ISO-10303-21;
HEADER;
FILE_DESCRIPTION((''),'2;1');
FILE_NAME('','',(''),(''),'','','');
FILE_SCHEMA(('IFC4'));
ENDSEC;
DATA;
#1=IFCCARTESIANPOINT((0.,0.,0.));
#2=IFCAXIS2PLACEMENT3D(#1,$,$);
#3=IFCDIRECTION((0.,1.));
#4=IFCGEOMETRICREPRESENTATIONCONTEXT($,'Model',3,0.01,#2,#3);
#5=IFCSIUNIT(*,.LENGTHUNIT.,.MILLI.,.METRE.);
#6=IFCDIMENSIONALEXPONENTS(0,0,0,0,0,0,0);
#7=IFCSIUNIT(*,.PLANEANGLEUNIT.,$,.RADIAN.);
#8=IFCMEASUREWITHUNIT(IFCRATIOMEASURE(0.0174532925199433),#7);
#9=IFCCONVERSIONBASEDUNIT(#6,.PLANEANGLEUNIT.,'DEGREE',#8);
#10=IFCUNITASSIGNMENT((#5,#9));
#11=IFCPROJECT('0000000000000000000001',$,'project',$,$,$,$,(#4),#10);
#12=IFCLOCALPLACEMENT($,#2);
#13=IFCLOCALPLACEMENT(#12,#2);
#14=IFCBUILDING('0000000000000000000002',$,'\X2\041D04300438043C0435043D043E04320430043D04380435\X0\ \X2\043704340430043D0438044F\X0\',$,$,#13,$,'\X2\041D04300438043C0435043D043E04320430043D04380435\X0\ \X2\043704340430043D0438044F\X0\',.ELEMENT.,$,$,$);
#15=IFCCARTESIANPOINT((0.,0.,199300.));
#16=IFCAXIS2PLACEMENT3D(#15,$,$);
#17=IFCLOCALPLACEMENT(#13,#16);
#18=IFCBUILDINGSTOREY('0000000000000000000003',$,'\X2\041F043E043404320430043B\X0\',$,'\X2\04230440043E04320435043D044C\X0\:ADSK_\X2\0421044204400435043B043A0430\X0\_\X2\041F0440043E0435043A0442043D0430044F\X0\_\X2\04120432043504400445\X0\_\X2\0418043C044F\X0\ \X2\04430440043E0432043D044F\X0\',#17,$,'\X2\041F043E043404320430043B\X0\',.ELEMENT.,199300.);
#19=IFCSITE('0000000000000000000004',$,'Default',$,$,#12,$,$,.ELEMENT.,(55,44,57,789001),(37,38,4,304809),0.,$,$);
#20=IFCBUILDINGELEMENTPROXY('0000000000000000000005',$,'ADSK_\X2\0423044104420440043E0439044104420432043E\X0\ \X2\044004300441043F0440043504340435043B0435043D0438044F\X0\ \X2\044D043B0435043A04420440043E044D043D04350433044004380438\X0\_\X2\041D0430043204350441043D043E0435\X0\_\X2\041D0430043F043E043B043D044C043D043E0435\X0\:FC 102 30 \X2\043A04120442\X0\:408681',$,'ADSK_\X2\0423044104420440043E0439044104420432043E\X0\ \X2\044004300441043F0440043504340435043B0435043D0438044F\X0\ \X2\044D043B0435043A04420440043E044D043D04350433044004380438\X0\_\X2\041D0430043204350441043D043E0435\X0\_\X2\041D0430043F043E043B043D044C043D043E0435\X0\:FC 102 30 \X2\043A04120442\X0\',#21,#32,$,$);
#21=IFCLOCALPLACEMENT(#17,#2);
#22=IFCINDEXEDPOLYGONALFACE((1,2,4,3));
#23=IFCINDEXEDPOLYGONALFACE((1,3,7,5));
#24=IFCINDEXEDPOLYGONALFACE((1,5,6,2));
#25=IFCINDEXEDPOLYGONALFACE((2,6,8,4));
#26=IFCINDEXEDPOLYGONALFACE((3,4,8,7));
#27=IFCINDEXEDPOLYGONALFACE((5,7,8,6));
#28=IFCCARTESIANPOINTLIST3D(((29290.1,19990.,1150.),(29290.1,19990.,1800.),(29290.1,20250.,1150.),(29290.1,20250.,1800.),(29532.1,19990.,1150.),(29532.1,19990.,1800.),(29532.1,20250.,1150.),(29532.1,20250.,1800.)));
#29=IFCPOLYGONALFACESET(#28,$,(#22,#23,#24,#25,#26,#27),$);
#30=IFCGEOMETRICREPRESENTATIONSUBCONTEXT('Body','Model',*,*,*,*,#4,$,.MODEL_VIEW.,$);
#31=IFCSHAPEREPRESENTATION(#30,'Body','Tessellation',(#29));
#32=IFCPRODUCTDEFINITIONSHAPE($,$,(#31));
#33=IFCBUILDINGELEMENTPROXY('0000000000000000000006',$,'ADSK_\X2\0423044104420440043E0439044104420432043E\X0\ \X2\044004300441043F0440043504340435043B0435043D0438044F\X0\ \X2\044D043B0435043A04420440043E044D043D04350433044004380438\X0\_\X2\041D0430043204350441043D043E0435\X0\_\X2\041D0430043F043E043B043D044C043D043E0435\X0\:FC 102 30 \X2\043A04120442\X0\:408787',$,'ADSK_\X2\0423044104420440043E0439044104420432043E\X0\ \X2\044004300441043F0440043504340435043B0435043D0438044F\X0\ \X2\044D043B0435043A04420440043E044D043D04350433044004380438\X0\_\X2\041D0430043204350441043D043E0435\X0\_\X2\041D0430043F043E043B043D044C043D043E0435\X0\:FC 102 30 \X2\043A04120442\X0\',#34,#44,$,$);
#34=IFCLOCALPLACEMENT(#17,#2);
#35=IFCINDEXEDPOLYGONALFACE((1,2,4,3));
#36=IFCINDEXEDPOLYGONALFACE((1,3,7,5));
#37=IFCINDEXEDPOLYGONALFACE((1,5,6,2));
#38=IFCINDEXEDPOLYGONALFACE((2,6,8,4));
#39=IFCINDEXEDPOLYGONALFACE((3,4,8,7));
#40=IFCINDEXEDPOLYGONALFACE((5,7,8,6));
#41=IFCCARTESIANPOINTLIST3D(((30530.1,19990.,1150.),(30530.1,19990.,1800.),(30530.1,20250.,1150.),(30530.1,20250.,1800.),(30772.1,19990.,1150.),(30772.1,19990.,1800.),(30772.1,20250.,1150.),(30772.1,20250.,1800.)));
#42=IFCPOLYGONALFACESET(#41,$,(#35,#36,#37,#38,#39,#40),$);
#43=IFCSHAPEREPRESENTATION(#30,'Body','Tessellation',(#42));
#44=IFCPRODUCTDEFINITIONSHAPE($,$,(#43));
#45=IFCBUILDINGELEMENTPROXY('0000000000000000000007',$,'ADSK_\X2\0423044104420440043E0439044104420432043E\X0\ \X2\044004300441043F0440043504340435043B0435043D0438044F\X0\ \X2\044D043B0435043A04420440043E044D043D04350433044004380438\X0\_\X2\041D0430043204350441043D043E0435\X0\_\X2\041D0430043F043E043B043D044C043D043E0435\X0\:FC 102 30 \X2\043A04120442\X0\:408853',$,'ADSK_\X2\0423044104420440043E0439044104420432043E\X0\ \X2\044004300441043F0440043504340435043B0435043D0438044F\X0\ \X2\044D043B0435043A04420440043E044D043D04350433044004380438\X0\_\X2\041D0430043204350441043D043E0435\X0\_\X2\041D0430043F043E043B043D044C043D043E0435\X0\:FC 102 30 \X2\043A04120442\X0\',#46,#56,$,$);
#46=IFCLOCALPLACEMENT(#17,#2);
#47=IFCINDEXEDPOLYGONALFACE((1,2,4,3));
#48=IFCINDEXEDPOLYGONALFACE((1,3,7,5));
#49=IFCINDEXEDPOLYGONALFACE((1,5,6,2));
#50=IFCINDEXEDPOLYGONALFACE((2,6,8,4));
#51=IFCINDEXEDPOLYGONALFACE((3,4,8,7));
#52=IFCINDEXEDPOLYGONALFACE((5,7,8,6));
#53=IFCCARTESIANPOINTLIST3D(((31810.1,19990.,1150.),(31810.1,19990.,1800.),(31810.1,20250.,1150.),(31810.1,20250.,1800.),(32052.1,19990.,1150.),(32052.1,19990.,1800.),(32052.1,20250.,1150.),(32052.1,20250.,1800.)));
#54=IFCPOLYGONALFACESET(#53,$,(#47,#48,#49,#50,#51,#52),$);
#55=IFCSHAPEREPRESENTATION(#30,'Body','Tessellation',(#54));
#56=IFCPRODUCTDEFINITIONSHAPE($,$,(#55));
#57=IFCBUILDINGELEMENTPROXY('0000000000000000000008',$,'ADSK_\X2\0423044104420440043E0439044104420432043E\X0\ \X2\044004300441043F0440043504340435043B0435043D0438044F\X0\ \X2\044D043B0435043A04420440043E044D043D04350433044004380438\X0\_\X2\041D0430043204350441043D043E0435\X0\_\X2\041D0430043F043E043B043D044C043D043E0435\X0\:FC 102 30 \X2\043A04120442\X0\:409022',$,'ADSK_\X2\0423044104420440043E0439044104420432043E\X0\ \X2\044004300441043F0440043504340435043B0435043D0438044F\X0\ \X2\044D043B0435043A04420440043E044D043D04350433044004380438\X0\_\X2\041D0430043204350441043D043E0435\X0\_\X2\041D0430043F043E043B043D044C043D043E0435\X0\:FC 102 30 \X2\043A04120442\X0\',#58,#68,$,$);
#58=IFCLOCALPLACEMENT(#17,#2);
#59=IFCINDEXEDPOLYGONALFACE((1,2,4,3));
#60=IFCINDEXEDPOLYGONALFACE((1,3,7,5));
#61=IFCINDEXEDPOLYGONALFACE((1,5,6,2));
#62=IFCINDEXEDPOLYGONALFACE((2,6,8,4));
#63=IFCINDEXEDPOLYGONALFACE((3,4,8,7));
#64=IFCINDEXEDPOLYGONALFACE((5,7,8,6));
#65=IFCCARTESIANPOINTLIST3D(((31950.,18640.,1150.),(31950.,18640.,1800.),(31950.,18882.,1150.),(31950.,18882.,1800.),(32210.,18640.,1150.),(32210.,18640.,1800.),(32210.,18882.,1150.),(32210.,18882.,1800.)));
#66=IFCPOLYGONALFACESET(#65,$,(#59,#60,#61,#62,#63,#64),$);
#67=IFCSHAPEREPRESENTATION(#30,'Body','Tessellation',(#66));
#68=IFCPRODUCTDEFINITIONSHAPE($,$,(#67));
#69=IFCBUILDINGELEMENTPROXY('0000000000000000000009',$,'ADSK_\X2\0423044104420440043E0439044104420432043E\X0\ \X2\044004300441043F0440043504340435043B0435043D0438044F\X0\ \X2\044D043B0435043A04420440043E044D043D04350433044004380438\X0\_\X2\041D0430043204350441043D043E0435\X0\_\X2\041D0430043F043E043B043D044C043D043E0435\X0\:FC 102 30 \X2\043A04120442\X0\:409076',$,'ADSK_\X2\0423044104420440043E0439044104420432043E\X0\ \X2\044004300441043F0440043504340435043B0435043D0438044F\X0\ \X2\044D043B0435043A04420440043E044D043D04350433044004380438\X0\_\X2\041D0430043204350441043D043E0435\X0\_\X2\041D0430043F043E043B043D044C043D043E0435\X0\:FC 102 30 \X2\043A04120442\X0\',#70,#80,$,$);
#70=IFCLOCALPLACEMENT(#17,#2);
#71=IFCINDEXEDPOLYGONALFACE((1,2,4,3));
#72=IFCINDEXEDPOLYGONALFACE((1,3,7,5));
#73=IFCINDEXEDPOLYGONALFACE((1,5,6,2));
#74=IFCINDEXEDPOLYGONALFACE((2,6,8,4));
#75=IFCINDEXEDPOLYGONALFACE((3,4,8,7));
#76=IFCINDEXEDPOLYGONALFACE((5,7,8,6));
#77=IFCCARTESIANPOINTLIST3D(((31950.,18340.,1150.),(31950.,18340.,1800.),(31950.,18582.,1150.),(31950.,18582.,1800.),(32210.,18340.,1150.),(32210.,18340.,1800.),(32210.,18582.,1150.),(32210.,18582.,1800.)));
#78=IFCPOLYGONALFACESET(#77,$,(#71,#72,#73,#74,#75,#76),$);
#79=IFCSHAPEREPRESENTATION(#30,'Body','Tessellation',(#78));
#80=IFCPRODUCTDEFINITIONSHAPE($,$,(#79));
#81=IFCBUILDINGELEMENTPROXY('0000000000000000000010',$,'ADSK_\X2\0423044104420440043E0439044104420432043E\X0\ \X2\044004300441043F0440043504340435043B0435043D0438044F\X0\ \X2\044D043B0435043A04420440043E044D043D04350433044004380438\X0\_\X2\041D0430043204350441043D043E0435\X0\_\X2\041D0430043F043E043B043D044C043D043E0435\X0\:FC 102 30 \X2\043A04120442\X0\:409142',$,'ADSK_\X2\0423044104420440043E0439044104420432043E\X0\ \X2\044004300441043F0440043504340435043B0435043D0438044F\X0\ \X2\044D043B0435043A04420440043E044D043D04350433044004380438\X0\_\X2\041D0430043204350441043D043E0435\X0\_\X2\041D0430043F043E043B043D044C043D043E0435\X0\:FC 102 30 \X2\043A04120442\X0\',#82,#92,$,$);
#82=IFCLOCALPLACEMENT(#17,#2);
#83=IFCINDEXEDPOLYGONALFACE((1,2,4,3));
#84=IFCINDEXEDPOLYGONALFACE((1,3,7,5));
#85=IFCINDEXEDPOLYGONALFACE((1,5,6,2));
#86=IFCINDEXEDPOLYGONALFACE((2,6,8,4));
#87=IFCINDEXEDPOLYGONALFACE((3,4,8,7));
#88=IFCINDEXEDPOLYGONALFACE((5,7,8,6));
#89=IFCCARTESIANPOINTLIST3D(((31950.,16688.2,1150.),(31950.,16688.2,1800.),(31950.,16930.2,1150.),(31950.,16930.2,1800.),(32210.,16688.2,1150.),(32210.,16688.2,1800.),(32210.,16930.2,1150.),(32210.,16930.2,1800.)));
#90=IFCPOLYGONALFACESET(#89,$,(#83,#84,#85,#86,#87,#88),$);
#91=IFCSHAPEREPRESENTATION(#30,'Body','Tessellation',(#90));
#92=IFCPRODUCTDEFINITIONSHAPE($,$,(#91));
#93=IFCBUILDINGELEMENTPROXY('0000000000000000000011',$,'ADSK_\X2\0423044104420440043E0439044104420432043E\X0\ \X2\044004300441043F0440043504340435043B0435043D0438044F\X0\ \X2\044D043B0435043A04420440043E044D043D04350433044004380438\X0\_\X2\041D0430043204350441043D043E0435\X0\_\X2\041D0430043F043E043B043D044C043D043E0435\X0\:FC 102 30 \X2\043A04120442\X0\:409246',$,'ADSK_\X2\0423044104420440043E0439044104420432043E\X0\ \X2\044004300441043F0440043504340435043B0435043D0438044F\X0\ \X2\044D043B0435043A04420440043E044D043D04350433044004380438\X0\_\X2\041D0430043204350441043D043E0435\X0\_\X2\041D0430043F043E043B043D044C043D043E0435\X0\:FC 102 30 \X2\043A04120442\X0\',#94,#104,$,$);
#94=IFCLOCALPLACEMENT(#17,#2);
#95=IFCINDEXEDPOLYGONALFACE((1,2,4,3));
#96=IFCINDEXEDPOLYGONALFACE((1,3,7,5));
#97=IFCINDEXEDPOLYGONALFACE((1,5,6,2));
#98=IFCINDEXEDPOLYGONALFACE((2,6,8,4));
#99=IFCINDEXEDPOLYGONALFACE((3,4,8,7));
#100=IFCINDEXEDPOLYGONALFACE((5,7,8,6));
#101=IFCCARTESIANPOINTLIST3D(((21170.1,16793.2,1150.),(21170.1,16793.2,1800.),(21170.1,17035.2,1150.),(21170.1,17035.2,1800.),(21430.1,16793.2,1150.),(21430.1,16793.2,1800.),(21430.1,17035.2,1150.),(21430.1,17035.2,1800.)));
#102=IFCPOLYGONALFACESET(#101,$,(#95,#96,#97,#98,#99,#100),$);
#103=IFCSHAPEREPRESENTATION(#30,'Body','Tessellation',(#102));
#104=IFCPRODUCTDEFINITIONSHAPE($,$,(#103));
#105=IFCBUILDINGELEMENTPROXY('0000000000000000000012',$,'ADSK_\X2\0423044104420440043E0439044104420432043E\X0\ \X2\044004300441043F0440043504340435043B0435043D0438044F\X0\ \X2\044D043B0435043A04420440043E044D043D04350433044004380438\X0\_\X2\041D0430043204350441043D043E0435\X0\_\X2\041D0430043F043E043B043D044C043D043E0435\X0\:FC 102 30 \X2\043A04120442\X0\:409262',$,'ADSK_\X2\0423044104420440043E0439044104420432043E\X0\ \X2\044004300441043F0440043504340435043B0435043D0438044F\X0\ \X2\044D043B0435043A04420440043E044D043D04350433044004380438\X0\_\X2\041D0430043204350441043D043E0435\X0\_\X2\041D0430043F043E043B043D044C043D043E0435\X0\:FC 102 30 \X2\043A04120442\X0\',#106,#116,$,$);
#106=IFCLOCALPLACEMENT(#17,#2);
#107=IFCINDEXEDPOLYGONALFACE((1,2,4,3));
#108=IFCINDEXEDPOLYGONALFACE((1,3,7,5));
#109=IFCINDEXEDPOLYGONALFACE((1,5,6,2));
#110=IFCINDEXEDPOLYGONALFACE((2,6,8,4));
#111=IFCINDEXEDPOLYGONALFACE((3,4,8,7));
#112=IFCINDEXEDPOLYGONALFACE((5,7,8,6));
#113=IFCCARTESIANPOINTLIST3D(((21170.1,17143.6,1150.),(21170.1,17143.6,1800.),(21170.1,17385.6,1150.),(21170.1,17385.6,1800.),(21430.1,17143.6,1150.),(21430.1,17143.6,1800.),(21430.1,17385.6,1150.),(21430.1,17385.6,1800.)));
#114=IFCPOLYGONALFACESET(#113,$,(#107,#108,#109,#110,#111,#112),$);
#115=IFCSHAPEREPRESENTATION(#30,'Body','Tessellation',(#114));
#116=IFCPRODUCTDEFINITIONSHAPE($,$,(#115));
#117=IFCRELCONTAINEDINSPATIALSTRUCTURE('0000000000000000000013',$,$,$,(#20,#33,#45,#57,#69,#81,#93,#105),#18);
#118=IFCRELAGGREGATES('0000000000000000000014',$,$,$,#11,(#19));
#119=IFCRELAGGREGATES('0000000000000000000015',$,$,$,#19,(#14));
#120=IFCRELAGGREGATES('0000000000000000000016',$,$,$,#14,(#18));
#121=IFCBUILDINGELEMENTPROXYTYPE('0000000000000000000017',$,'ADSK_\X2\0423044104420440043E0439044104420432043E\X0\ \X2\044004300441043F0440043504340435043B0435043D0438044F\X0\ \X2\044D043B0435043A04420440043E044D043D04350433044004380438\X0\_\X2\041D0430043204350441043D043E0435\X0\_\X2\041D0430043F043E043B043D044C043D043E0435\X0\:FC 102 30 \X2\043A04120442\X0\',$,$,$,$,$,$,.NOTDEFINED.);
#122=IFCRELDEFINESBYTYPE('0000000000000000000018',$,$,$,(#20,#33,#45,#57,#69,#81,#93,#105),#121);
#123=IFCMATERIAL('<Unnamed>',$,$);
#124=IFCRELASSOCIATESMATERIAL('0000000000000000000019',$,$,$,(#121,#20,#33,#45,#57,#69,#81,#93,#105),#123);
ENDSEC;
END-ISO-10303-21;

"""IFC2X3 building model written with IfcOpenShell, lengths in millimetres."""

from ifc_helpers import new_model, entity, si_unit, converted_unit, direction, frame, origin, origin_2d_with_axis, place, context, subcontext, project, spatial, rectangle, extrude, source, transform, mapped, material, type_object, type_shapes, element, save


model = new_model("IFC2X3")

# Units and contexts
model_context = context("Model", 3, precision=0.01, world=origin(), true_north=direction((0.0, 1.0)))
body_context = subcontext(model_context, "Body", "Model", "MODEL_VIEW")
ifc_project = project(units=[si_unit("LENGTHUNIT", "METRE", prefix="MILLI"), converted_unit("PLANEANGLEUNIT", "DEGREE", entity("IfcRatioMeasure", 0.0174532925199433), si_unit("PLANEANGLEUNIT", "RADIAN"), dimensions=[0, 0, 0, 0, 0, 0, 0])], contexts=[model_context])

# Site, building, storey
site_placement = place(None, origin())
site = spatial("IfcSite", under=ifc_project, at=site_placement, Name="Default", CompositionType="ELEMENT", RefLatitude=(55, 44, 57, 789001), RefLongitude=(37, 38, 4, 304809), RefElevation=0.0)
building_placement = place(site_placement, origin())
building = spatial("IfcBuilding", under=site, at=building_placement, Name="Наименование здания", LongName="Наименование здания", CompositionType="ELEMENT")
storey_placement = place(building_placement, frame((0.0, 0.0, 199300.0)))
storey = spatial("IfcBuildingStorey", under=building, at=storey_placement, Name="Подвал", ObjectType="Уровень:ADSK_Стрелка_Проектная_Вверх_Имя уровня", LongName="Подвал", CompositionType="ELEMENT", Elevation=199300.0)

# Shared definitions
ifc_material = material(Name="<Unnamed>")

# Building element proxies
building_element_proxy_type = type_object("IfcBuildingElementProxyType", Name="ADSK_Устройство распределения электроэнегрии_Навесное_Наполньное:FC 102 30 кВт", PredefinedType="NOTDEFINED", material=ifc_material)
shared_shape_1 = source(origin(), body_context, "Body", "SweptSolid", [
    extrude(rectangle(XDim=242.0, YDim=260.0, at=origin_2d_with_axis()), frame((0.0, 130.0, -650.0), z_axis=(0.0, 0.0, 1.0), x_axis=(-1.0, 0.0, 0.0)), (0.0, 0.0, 1.0), 650.0),
])
type_shapes(building_element_proxy_type, [shared_shape_1])
for number, where, z_axis, x_axis, name in (
    (1, (29411.1, 20250.0, 1800.0), (0.0, 0.0, 1.0), (-1.0, 0.0, 0.0), "ADSK_Устройство распределения электроэнегрии_Навесное_Наполньное:FC 102 30 кВт:408681"),
    (2, (30651.1, 20250.0, 1800.0), (0.0, 0.0, 1.0), (-1.0, 0.0, 0.0), "ADSK_Устройство распределения электроэнегрии_Навесное_Наполньное:FC 102 30 кВт:408787"),
    (3, (31931.1, 20250.0, 1800.0), (0.0, 0.0, 1.0), (-1.0, 0.0, 0.0), "ADSK_Устройство распределения электроэнегрии_Навесное_Наполньное:FC 102 30 кВт:408853"),
    (4, (32210.0, 18761.0, 1800.0), (0.0, 0.0, 1.0), (0.0, 1.0, 0.0), "ADSK_Устройство распределения электроэнегрии_Навесное_Наполньное:FC 102 30 кВт:409022"),
    (5, (32210.0, 18461.0, 1800.0), (0.0, 0.0, 1.0), (0.0, 1.0, 0.0), "ADSK_Устройство распределения электроэнегрии_Навесное_Наполньное:FC 102 30 кВт:409076"),
    (6, (32210.0, 16809.2, 1800.0), (0.0, 0.0, 1.0), (0.0, 1.0, 0.0), "ADSK_Устройство распределения электроэнегрии_Навесное_Наполньное:FC 102 30 кВт:409142"),
    (7, (21170.1, 16914.2, 1800.0), (0.0, 0.0, 1.0), (0.0, -1.0, 0.0), "ADSK_Устройство распределения электроэнегрии_Навесное_Наполньное:FC 102 30 кВт:409246"),
    (8, (21170.1, 17264.6, 1800.0), (0.0, 0.0, 1.0), (0.0, -1.0, 0.0), "ADSK_Устройство распределения электроэнегрии_Навесное_Наполньное:FC 102 30 кВт:409262"),
):
    element("IfcBuildingElementProxy", number, at=place(storey_placement, frame(where, z_axis=z_axis, x_axis=x_axis)), inside=storey, type_object=building_element_proxy_type, material=ifc_material, Name=name, ObjectType="ADSK_Устройство распределения электроэнегрии_Навесное_Наполньное:FC 102 30 кВт", context=body_context, shape_type="MappedRepresentation", body=[
        mapped(shared_shape_1, transform((0.0, 0.0, 0.0), scale=1.0)),
    ])

save(model, "model.ifc")
